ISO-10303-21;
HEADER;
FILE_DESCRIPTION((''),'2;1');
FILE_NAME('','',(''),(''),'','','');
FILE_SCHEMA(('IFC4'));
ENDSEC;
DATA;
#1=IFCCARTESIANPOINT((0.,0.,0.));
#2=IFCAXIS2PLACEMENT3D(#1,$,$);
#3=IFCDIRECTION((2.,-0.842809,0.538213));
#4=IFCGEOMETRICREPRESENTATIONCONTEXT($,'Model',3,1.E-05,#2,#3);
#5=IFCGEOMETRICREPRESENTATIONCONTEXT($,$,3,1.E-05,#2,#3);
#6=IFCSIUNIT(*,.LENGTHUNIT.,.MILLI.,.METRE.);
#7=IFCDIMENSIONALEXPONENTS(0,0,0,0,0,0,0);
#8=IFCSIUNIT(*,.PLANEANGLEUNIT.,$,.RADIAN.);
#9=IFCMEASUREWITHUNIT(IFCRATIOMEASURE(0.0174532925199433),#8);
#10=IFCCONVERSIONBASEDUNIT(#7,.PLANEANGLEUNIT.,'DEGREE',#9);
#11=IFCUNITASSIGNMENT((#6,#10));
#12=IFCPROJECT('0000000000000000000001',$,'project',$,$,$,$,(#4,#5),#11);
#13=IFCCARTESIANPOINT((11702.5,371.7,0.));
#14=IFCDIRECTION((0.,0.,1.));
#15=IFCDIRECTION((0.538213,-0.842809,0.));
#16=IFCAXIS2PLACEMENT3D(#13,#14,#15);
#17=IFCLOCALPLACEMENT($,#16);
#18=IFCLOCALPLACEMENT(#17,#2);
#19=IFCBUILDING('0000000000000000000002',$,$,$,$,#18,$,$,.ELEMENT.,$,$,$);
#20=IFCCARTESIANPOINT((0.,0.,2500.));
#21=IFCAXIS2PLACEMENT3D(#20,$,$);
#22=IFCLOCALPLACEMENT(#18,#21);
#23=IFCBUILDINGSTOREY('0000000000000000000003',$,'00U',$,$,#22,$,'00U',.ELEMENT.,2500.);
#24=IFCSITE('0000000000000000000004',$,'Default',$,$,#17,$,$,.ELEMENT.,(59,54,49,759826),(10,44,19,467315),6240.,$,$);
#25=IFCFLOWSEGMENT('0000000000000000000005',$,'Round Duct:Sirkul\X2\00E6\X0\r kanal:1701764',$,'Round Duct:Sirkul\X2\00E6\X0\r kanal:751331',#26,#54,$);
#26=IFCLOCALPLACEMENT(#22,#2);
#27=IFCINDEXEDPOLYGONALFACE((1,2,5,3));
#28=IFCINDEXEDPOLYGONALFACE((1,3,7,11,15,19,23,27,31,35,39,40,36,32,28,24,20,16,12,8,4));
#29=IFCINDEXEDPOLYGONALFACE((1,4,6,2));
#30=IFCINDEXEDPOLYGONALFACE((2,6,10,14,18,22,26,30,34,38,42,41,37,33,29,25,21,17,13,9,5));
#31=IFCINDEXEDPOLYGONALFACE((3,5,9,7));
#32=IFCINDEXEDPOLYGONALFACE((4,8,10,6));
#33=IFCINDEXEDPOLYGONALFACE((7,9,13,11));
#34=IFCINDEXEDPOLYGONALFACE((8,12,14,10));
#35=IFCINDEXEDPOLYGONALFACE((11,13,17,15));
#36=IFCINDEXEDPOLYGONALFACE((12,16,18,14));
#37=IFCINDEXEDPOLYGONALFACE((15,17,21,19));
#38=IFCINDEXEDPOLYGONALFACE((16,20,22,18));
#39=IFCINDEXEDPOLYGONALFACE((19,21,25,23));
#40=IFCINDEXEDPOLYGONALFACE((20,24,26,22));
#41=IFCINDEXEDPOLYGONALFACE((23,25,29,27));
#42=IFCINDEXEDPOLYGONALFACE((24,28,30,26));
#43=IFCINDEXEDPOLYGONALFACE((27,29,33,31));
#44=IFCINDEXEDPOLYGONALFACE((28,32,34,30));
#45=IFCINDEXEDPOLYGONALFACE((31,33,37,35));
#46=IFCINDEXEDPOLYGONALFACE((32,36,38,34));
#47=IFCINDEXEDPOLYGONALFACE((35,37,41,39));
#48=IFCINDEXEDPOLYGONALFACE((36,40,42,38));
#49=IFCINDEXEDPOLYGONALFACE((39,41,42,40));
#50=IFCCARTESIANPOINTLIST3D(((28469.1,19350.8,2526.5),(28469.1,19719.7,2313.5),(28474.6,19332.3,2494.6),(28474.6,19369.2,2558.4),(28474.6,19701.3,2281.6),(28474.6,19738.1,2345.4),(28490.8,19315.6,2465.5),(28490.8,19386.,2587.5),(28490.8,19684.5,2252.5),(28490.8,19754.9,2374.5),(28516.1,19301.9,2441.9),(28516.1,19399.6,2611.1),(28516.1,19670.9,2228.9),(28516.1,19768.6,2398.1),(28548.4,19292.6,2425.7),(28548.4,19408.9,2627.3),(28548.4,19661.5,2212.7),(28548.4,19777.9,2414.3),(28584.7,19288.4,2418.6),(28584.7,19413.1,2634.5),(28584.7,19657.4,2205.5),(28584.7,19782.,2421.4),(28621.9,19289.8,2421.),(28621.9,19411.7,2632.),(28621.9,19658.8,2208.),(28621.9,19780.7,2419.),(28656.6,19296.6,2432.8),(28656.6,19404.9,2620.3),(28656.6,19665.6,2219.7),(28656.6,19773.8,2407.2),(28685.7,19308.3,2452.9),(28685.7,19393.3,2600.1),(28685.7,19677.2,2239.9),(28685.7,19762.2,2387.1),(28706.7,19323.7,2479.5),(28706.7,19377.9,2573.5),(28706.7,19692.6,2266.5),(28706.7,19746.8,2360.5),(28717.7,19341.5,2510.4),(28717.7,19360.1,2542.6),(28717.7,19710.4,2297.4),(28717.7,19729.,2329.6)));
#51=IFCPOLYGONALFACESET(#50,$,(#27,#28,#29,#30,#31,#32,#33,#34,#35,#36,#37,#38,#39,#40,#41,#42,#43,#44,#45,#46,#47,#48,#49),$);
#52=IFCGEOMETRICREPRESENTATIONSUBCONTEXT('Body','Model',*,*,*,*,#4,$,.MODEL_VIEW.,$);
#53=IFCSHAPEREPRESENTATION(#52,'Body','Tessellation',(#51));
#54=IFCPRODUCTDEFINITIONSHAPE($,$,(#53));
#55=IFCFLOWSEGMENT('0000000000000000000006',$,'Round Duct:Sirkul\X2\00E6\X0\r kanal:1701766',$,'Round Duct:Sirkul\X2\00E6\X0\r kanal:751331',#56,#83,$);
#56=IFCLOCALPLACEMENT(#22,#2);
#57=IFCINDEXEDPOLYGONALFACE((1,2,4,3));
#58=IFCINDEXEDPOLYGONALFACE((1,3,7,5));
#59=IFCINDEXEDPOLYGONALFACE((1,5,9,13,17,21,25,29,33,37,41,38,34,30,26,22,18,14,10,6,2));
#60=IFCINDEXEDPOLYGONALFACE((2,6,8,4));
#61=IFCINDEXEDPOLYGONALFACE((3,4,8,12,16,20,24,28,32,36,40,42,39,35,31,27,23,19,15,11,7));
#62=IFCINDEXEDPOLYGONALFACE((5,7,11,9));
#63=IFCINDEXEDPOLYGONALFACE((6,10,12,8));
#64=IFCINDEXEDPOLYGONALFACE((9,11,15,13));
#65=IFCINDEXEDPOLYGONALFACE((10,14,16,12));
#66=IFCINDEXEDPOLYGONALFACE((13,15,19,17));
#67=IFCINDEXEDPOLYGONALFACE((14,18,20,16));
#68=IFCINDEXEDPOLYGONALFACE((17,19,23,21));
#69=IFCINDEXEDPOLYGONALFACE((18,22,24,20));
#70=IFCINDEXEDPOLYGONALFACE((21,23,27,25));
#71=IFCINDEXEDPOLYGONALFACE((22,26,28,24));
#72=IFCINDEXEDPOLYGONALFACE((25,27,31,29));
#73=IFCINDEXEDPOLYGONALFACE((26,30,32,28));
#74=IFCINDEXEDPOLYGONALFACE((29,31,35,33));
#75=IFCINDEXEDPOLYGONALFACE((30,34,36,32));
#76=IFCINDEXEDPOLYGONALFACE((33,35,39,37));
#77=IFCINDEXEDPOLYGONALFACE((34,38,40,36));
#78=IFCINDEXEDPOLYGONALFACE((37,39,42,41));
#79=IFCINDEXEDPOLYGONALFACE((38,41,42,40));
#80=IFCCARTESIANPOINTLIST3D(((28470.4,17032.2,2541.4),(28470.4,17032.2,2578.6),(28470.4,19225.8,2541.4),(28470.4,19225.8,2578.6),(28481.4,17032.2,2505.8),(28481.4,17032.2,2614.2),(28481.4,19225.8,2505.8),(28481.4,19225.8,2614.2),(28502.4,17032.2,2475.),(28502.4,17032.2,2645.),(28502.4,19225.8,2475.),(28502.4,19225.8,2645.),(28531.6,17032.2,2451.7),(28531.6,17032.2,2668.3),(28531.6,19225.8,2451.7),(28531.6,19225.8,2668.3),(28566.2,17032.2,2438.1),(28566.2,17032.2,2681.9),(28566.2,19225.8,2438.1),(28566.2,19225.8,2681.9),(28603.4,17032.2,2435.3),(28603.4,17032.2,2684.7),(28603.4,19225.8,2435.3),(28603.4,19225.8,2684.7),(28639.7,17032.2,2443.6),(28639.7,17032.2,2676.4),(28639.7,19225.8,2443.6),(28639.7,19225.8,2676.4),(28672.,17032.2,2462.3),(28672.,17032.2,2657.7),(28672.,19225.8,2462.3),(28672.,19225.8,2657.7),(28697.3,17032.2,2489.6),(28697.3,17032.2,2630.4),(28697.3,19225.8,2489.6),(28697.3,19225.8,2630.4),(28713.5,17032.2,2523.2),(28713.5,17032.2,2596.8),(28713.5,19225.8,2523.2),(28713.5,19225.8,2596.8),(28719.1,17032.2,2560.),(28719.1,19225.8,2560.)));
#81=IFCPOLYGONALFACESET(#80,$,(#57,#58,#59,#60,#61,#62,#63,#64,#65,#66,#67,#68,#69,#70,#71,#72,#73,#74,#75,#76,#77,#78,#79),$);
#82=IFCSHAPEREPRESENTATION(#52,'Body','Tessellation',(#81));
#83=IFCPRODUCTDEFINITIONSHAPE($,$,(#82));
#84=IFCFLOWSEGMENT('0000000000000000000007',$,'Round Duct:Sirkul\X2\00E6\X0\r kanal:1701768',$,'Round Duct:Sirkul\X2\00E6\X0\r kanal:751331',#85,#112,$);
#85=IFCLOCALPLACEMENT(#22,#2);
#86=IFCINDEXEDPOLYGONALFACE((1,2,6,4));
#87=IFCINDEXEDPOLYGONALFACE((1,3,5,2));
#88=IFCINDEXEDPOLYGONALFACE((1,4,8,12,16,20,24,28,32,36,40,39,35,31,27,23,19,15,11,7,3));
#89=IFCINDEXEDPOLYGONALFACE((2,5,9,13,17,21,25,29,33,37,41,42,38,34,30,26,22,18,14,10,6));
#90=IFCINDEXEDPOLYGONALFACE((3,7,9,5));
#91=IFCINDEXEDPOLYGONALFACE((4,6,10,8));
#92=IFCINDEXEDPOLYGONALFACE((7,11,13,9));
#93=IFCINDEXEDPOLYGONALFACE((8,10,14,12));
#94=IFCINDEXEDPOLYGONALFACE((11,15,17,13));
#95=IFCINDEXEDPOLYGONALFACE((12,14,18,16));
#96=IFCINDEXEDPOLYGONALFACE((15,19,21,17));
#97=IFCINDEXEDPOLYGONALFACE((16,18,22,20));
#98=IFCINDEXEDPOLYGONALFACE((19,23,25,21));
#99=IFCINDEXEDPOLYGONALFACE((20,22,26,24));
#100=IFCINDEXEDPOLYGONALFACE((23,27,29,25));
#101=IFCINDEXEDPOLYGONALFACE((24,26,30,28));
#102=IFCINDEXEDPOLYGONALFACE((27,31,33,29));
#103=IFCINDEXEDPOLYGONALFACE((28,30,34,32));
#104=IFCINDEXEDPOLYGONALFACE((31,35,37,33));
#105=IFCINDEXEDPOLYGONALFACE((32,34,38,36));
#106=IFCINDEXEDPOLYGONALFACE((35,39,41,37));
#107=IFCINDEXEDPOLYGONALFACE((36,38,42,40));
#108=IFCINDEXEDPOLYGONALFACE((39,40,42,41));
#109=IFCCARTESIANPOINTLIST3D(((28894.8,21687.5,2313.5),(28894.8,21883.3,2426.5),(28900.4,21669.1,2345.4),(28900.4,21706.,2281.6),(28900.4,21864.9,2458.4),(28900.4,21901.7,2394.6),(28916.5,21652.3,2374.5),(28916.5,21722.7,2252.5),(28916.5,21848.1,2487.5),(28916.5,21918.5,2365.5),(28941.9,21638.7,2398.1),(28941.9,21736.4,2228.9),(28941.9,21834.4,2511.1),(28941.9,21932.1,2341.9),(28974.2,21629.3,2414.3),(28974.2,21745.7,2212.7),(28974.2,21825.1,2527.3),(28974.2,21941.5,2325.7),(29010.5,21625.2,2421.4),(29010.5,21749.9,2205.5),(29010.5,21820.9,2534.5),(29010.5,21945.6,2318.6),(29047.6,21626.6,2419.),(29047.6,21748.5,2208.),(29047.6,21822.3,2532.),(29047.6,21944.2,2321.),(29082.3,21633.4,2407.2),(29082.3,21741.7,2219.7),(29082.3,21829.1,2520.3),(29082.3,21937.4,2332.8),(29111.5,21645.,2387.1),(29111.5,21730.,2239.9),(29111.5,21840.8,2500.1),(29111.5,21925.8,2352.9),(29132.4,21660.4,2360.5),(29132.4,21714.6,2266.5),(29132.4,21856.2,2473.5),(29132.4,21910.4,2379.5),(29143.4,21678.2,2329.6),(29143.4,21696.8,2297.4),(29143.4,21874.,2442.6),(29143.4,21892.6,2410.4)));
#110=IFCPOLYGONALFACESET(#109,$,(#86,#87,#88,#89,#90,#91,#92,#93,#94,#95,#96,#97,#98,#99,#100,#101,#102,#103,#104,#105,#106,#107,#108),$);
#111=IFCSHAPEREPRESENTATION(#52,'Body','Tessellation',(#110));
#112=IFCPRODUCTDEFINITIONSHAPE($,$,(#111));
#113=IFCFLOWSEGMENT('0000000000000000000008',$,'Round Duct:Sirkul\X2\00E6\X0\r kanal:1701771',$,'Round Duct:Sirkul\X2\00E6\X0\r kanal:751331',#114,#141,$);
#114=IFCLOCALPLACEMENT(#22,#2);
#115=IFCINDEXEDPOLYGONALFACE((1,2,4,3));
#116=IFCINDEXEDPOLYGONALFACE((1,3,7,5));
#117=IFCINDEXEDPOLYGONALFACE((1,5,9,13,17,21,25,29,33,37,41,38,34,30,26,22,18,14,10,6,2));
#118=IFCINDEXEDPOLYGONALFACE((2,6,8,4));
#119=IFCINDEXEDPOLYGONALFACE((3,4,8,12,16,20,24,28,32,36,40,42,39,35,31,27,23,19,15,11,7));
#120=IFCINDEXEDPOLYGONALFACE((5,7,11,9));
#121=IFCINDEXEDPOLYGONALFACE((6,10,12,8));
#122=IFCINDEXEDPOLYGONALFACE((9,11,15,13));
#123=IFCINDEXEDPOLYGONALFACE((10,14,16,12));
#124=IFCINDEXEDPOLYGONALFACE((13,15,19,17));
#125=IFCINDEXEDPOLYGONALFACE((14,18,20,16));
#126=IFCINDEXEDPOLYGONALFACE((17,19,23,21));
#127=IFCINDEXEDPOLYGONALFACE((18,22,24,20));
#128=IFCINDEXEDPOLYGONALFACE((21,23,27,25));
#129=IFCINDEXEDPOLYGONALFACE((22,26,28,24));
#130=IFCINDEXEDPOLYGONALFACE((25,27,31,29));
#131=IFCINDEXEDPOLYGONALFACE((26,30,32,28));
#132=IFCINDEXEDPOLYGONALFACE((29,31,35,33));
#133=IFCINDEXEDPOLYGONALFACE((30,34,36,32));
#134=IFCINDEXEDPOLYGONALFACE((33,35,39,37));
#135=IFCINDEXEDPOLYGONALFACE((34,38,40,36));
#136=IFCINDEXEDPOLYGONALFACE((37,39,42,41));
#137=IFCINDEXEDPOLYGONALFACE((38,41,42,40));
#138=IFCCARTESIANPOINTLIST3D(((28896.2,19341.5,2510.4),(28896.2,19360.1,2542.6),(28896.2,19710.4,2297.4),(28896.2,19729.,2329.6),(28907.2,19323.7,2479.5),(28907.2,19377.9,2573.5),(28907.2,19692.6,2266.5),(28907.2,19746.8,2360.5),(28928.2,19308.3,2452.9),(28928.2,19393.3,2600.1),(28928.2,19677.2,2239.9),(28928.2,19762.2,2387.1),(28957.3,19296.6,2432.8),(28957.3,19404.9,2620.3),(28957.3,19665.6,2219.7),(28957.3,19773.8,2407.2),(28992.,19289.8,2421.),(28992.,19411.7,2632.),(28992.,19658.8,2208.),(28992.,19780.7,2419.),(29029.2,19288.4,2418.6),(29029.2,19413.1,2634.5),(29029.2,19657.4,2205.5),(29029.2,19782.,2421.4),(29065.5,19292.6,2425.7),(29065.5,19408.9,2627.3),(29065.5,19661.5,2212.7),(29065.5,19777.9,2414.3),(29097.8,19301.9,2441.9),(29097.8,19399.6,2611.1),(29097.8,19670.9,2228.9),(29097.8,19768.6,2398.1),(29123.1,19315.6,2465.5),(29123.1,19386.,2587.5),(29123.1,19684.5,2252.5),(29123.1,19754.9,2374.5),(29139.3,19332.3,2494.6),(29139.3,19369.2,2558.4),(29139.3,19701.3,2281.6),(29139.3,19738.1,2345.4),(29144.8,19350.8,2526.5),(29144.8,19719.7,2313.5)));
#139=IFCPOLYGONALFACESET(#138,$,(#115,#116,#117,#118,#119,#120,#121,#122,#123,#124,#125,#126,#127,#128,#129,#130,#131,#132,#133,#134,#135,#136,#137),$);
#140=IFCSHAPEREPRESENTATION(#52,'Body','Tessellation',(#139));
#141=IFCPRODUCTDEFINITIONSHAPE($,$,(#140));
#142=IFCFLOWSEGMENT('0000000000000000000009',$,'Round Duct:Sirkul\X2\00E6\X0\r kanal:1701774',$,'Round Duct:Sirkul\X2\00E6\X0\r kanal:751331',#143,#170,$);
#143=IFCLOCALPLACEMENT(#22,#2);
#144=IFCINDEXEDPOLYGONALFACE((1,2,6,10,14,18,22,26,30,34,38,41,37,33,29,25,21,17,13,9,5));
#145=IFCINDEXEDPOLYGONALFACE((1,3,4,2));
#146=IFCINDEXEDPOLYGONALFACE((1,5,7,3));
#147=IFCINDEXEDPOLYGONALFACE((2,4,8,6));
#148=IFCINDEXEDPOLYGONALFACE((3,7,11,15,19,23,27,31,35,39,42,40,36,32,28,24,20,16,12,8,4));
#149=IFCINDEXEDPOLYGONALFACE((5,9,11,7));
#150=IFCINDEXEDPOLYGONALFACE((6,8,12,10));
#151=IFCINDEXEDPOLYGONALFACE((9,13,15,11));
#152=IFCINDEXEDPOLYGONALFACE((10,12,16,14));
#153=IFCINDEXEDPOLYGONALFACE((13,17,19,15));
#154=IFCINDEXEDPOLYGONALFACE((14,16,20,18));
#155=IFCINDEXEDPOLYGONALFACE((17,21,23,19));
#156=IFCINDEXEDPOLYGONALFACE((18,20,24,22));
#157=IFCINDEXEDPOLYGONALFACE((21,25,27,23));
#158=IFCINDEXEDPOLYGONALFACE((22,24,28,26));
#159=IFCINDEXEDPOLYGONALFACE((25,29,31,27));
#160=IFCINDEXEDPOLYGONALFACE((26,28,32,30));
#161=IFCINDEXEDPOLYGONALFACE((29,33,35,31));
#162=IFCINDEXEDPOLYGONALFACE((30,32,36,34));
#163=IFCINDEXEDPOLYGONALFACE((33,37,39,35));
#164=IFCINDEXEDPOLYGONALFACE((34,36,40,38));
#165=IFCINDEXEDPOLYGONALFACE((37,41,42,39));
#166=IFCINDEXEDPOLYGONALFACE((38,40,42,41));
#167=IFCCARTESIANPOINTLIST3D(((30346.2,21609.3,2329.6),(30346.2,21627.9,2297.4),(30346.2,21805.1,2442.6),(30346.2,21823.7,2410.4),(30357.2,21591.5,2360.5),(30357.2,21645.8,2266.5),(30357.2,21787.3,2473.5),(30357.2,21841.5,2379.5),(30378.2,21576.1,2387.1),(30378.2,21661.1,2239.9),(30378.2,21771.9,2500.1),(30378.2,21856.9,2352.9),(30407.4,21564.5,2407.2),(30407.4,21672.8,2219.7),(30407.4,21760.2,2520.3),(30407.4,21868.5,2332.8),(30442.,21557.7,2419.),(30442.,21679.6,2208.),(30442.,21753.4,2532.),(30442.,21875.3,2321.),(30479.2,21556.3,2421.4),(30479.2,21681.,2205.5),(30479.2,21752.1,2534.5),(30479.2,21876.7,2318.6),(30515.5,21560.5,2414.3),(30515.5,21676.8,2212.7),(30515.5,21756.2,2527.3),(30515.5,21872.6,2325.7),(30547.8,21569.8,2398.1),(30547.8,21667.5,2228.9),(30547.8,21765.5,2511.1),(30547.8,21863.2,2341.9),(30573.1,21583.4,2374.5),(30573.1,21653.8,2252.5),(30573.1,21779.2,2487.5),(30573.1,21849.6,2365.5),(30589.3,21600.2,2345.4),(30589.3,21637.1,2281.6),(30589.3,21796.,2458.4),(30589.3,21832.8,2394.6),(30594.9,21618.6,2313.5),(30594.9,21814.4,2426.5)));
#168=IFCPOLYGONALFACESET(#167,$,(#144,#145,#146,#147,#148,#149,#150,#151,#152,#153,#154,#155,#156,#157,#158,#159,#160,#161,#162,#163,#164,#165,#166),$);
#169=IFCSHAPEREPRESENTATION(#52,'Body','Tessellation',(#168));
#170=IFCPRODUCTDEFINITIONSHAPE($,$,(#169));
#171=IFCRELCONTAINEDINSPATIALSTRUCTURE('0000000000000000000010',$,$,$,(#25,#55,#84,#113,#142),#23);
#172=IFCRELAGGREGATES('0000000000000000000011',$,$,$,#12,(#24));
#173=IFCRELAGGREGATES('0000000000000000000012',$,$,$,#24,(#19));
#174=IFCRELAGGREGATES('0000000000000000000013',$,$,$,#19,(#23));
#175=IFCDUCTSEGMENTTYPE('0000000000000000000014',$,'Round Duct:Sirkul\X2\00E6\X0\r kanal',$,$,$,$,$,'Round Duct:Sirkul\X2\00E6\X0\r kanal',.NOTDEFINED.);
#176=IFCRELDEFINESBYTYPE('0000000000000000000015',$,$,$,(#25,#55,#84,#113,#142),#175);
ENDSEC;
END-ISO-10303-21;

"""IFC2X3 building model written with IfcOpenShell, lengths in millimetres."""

from ifc_helpers import new_model, entity, si_unit, converted_unit, direction, frame, frame_2d, origin, origin_2d_with_axis, place, context, subcontext, project, spatial, circle, extrude, type_object, element, save


model = new_model("IFC2X3")

# Units and contexts
model_context = context("Model", 3, precision=1e-05, world=origin(), true_north=direction((2.0, -0.842809, 0.538213)))
context_of_model = context(None, 3, precision=1e-05, world=origin(), true_north=direction((2.0, -0.842809, 0.538213)))
body_context = subcontext(model_context, "Body", "Model", "MODEL_VIEW")
ifc_project = project(units=[si_unit("LENGTHUNIT", "METRE", prefix="MILLI"), converted_unit("PLANEANGLEUNIT", "DEGREE", entity("IfcRatioMeasure", 0.0174532925199433), si_unit("PLANEANGLEUNIT", "RADIAN"), dimensions=[0, 0, 0, 0, 0, 0, 0])], contexts=[model_context, context_of_model])

# Site, building, storey
site_placement = place(None, frame((11702.5, 371.7, 0.0), z_axis=(0.0, 0.0, 1.0), x_axis=(0.538213, -0.842809, 0.0)))
site = spatial("IfcSite", under=ifc_project, at=site_placement, Name="Default", CompositionType="ELEMENT", RefLatitude=(59, 54, 49, 759826), RefLongitude=(10, 44, 19, 467315), RefElevation=6240.0)
building_placement = place(site_placement, origin())
building = spatial("IfcBuilding", under=site, at=building_placement, CompositionType="ELEMENT")
storey_placement = place(building_placement, frame((0.0, 0.0, 2500.0)))
storey = spatial("IfcBuildingStorey", under=building, at=storey_placement, Name="00U", LongName="00U", CompositionType="ELEMENT", Elevation=2500.0)

# Flow segments
duct_segment_type = type_object("IfcDuctSegmentType", Name="Round Duct:Sirkulær kanal", ElementType="Round Duct:Sirkulær kanal", PredefinedType="NOTDEFINED")
flow_segment_1_placement = place(storey_placement, origin())
element("IfcFlowSegment", 1, at=flow_segment_1_placement, inside=storey, type_object=duct_segment_type, Name="Round Duct:Sirkulær kanal:1701764", ObjectType="Round Duct:Sirkulær kanal:751331", context=body_context, shape_type="SweptSolid", body=[
    extrude(circle(Radius=125.0, at=frame_2d((0.0, 0.0), x_axis=(1.0, 0.0))), frame((28594.1, 19719.7, 2313.5), z_axis=(0.0, -0.866025, 0.5), x_axis=(-1.0, 0.0, 0.0)), (0.0, 0.0, 1.0), 426.0),
])
flow_segment_2_placement = place(storey_placement, origin())
element("IfcFlowSegment", 2, at=flow_segment_2_placement, inside=storey, type_object=duct_segment_type, Name="Round Duct:Sirkulær kanal:1701766", ObjectType="Round Duct:Sirkulær kanal:751331", context=body_context, shape_type="SweptSolid", body=[
    extrude(circle(Radius=125.0, at=origin_2d_with_axis()), frame((28594.1, 17032.2, 2560.0), z_axis=(0.0, 1.0, 0.0), x_axis=(1.0, 0.0, 0.0)), (0.0, 0.0, 1.0), 2193.6),
])
flow_segment_3_placement = place(storey_placement, origin())
element("IfcFlowSegment", 3, at=flow_segment_3_placement, inside=storey, type_object=duct_segment_type, Name="Round Duct:Sirkulær kanal:1701768", ObjectType="Round Duct:Sirkulær kanal:751331", context=body_context, shape_type="SweptSolid", body=[
    extrude(circle(Radius=125.0, at=frame_2d((0.0, 0.0), x_axis=(1.0, 0.0))), frame((29019.8, 21687.5, 2313.5), z_axis=(0.0, 0.866025, 0.5), x_axis=(-1.0, 0.0, 0.0)), (0.0, 0.0, 1.0), 226.0),
])
flow_segment_4_placement = place(storey_placement, origin())
element("IfcFlowSegment", 4, at=flow_segment_4_placement, inside=storey, type_object=duct_segment_type, Name="Round Duct:Sirkulær kanal:1701771", ObjectType="Round Duct:Sirkulær kanal:751331", context=body_context, shape_type="SweptSolid", body=[
    extrude(circle(Radius=125.0, at=frame_2d((0.0, 0.0), x_axis=(1.0, 0.0))), frame((29019.8, 19719.7, 2313.5), z_axis=(0.0, -0.866025, 0.5), x_axis=(1.0, 0.0, 0.0)), (0.0, 0.0, 1.0), 426.0),
])
flow_segment_5_placement = place(storey_placement, origin())
element("IfcFlowSegment", 5, at=flow_segment_5_placement, inside=storey, type_object=duct_segment_type, Name="Round Duct:Sirkulær kanal:1701774", ObjectType="Round Duct:Sirkulær kanal:751331", context=body_context, shape_type="SweptSolid", body=[
    extrude(circle(Radius=125.0, at=frame_2d((0.0, 0.0), x_axis=(1.0, 0.0))), frame((30469.9, 21618.6, 2313.5), z_axis=(0.0, 0.866025, 0.5), x_axis=(1.0, 0.0, 0.0)), (0.0, 0.0, 1.0), 226.0),
])

save(model, "model.ifc")
